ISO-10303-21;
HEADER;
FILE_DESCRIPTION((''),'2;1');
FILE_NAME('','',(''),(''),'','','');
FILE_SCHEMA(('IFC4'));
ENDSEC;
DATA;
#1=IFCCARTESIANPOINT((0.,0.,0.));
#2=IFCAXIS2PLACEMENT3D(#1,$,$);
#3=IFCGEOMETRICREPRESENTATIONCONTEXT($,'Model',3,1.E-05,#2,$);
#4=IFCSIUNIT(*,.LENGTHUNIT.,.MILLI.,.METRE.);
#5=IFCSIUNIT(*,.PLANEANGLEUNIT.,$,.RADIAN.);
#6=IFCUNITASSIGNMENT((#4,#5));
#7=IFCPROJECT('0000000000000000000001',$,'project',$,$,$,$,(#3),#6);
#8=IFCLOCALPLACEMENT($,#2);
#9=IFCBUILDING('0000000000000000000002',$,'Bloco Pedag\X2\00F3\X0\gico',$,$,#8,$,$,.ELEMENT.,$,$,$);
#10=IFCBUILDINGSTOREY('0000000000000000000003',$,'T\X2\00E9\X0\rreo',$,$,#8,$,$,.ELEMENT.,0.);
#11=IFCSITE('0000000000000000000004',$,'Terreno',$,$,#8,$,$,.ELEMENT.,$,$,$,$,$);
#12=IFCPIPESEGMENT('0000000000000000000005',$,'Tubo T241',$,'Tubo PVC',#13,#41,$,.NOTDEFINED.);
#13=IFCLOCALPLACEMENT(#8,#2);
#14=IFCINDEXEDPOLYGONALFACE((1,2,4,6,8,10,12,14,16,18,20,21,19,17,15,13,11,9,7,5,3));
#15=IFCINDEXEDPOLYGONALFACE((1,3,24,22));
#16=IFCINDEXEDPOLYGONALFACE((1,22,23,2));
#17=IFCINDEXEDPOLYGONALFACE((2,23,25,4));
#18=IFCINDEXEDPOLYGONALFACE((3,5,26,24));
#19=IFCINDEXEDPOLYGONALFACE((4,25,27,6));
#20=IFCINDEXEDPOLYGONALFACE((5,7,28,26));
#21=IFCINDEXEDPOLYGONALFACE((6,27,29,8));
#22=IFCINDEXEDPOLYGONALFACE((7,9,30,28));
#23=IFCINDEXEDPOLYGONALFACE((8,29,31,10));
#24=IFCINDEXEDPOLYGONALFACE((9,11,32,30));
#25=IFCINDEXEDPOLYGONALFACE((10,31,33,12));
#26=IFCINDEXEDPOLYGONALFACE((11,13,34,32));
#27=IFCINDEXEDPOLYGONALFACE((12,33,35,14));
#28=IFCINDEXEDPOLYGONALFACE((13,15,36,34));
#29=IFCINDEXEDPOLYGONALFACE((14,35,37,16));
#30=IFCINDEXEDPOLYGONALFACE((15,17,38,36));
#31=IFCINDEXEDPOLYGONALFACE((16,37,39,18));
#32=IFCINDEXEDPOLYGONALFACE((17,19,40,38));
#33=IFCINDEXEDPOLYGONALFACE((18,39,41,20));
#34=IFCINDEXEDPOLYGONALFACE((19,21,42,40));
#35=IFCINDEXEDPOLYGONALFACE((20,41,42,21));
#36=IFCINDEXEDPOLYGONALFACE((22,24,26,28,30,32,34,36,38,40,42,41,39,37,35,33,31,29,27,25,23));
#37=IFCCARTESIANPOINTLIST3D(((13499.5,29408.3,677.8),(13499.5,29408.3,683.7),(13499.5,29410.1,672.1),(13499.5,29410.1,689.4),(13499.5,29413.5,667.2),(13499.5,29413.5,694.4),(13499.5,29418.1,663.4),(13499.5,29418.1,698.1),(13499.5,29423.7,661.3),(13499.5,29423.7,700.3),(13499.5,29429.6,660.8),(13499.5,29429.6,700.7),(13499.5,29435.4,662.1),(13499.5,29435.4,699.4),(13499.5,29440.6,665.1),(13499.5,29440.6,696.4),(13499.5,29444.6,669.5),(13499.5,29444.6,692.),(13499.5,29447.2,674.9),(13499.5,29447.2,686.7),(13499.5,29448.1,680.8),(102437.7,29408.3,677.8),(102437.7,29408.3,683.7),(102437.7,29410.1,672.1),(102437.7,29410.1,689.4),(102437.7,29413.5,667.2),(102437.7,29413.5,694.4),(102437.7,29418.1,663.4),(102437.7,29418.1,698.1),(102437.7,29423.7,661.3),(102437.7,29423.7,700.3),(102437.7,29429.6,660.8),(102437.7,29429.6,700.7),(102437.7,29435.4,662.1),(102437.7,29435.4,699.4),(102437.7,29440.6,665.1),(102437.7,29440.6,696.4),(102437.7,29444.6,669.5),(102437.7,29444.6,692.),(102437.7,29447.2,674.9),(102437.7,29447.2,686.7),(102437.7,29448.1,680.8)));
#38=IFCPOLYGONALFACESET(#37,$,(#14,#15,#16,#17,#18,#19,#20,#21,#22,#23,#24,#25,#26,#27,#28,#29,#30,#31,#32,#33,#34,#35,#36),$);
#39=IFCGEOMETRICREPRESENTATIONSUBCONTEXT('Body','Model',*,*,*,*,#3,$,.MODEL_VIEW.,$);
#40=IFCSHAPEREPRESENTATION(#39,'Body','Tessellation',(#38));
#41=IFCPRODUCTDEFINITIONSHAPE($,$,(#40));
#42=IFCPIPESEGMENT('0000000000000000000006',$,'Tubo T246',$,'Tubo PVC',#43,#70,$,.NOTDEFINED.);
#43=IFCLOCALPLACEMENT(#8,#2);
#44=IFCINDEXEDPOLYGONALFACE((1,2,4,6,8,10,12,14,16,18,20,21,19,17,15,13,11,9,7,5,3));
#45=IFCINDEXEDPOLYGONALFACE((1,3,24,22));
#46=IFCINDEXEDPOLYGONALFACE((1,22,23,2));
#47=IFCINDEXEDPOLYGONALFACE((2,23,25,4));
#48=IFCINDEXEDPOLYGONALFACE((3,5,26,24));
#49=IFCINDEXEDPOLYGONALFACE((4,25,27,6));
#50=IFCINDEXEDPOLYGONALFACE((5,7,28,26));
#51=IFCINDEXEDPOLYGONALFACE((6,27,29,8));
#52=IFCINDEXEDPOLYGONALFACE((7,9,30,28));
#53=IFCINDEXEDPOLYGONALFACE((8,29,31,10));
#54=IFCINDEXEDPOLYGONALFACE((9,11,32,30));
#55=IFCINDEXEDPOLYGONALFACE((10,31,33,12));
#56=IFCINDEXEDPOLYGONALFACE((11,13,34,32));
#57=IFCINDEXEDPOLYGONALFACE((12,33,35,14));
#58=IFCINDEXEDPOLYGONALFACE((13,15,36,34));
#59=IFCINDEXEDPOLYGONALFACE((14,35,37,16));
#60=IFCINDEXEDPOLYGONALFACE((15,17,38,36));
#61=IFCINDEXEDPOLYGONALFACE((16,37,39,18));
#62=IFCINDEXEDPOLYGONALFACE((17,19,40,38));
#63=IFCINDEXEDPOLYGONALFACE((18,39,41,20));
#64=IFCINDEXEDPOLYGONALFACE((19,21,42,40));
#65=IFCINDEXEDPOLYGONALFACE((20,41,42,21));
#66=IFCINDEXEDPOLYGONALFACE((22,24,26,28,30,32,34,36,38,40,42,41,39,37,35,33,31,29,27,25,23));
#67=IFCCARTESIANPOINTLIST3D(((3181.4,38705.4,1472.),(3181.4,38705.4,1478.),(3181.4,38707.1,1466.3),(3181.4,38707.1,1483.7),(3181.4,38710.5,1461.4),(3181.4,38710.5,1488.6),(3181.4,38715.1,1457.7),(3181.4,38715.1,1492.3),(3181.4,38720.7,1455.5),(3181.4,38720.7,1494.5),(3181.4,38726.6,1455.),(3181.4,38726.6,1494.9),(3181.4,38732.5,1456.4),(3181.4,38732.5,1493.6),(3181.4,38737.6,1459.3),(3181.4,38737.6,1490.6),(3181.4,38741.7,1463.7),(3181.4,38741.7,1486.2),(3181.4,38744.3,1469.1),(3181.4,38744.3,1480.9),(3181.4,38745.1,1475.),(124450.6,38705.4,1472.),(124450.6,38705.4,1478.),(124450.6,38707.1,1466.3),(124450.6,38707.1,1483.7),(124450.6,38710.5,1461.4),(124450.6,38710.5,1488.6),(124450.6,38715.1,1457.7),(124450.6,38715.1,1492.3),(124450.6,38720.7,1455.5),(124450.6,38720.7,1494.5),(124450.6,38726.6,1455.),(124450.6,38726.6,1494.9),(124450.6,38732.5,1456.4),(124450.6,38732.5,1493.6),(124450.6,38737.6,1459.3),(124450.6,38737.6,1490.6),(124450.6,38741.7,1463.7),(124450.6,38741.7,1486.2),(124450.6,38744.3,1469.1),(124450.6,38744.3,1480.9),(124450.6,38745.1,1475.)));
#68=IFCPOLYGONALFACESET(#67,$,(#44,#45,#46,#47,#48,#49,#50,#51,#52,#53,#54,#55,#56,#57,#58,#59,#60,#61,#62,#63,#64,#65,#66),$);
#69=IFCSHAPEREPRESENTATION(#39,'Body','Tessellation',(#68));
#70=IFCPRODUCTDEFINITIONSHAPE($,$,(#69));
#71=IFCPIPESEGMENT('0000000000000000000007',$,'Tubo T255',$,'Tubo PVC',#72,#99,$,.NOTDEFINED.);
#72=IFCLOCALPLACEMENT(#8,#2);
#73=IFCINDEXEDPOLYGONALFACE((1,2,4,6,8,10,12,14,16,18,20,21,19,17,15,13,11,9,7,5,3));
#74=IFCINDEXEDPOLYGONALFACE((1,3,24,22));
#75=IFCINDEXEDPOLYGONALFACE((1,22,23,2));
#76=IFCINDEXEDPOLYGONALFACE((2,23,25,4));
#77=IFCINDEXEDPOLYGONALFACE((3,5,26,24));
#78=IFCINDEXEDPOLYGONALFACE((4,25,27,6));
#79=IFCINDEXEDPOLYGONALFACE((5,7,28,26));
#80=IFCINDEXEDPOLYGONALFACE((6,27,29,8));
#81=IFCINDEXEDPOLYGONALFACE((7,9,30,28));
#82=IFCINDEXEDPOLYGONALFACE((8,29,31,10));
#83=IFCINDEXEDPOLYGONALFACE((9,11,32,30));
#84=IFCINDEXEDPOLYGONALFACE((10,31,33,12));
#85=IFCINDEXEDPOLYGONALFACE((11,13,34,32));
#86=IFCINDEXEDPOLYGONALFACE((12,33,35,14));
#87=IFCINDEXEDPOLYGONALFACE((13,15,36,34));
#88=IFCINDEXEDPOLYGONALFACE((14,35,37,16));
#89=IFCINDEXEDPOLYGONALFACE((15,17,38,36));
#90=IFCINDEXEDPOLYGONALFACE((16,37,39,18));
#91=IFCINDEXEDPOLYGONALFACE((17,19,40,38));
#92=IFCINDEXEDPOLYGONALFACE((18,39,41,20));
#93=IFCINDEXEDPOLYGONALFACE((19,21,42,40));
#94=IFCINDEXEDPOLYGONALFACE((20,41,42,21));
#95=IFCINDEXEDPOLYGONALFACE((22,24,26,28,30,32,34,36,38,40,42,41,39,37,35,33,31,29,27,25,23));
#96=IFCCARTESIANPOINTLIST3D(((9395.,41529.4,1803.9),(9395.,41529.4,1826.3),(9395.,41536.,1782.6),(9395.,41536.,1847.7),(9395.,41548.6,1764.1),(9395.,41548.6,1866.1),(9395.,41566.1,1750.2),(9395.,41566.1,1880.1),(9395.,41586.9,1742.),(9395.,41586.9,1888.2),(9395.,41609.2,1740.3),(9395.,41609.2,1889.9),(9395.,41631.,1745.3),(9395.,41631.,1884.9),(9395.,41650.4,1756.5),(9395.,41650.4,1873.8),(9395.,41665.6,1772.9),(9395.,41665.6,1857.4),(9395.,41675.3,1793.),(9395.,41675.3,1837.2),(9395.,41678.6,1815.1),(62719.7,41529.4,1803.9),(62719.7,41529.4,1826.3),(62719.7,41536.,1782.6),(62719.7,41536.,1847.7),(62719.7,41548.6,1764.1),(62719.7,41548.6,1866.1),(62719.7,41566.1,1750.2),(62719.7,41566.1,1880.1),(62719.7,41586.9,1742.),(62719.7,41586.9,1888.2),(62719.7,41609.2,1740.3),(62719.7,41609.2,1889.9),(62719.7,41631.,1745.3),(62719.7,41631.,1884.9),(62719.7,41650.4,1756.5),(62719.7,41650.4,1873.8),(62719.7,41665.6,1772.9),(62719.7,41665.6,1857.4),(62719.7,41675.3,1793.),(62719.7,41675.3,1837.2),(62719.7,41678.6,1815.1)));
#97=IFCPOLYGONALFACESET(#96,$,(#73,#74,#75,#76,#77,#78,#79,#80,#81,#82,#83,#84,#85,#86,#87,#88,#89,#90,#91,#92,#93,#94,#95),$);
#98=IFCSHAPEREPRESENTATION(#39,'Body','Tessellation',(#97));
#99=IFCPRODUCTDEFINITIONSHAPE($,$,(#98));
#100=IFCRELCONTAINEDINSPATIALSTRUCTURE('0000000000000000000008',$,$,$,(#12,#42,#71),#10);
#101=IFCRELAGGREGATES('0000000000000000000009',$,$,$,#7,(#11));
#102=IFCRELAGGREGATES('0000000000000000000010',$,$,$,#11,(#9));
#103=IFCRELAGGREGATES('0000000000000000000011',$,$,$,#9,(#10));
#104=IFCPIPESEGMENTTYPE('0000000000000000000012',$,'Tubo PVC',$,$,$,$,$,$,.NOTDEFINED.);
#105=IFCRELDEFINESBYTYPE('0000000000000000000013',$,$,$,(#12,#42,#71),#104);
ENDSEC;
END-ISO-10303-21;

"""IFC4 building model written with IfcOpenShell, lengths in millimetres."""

from ifc_helpers import new_model, si_unit, frame, origin, origin_2d, place, context, subcontext, project, spatial, circle, extrude, type_object, element, save


model = new_model("IFC4")

# Units and contexts
model_context = context("Model", 3, precision=1e-05, world=origin())
body_context = subcontext(model_context, "Body", "Model", "MODEL_VIEW")
ifc_project = project(units=[si_unit("LENGTHUNIT", "METRE", prefix="MILLI"), si_unit("PLANEANGLEUNIT", "RADIAN")], contexts=[model_context])

# Site, building, storey
placement = place(None, origin())
site = spatial("IfcSite", under=ifc_project, at=placement, Name="Terreno", CompositionType="ELEMENT")
building = spatial("IfcBuilding", under=site, at=placement, Name="Bloco Pedagógico", CompositionType="ELEMENT")
storey = spatial("IfcBuildingStorey", under=building, at=placement, Name="Térreo", CompositionType="ELEMENT", Elevation=0.0)

# Pipe segments
pipe_segment_type = type_object("IfcPipeSegmentType", Name="Tubo PVC", PredefinedType="NOTDEFINED")
pipe_segment_1_placement = place(None, frame((13499.5, 29428.1, 680.8), z_axis=(1.0, 0.0, 0.0), x_axis=(0.0, 1.0, 0.0)))
element("IfcPipeSegment", 1, at=pipe_segment_1_placement, inside=storey, type_object=pipe_segment_type, Name="Tubo T241", ObjectType="Tubo PVC", PredefinedType="NOTDEFINED", context=body_context, shape_type="SweptSolid", body=[
    extrude(circle(Radius=20.0, at=origin_2d()), None, (0.0, 0.0, 1.0), 88938.3),
])
pipe_segment_2_placement = place(None, frame((3181.4, 38725.1, 1475.0), z_axis=(1.0, 0.0, 0.0), x_axis=(0.0, 1.0, 0.0)))
element("IfcPipeSegment", 2, at=pipe_segment_2_placement, inside=storey, type_object=pipe_segment_type, Name="Tubo T246", ObjectType="Tubo PVC", PredefinedType="NOTDEFINED", context=body_context, shape_type="SweptSolid", body=[
    extrude(circle(Radius=20.0, at=origin_2d()), None, (0.0, 0.0, 1.0), 121269.2),
])
pipe_segment_3_placement = place(None, frame((9395.0, 41603.6, 1815.1), z_axis=(1.0, 0.0, 0.0), x_axis=(0.0, 1.0, 0.0)))
element("IfcPipeSegment", 3, at=pipe_segment_3_placement, inside=storey, type_object=pipe_segment_type, Name="Tubo T255", ObjectType="Tubo PVC", PredefinedType="NOTDEFINED", context=body_context, shape_type="SweptSolid", body=[
    extrude(circle(Radius=75.0, at=origin_2d()), None, (0.0, 0.0, 1.0), 53324.7),
])

save(model, "model.ifc")
